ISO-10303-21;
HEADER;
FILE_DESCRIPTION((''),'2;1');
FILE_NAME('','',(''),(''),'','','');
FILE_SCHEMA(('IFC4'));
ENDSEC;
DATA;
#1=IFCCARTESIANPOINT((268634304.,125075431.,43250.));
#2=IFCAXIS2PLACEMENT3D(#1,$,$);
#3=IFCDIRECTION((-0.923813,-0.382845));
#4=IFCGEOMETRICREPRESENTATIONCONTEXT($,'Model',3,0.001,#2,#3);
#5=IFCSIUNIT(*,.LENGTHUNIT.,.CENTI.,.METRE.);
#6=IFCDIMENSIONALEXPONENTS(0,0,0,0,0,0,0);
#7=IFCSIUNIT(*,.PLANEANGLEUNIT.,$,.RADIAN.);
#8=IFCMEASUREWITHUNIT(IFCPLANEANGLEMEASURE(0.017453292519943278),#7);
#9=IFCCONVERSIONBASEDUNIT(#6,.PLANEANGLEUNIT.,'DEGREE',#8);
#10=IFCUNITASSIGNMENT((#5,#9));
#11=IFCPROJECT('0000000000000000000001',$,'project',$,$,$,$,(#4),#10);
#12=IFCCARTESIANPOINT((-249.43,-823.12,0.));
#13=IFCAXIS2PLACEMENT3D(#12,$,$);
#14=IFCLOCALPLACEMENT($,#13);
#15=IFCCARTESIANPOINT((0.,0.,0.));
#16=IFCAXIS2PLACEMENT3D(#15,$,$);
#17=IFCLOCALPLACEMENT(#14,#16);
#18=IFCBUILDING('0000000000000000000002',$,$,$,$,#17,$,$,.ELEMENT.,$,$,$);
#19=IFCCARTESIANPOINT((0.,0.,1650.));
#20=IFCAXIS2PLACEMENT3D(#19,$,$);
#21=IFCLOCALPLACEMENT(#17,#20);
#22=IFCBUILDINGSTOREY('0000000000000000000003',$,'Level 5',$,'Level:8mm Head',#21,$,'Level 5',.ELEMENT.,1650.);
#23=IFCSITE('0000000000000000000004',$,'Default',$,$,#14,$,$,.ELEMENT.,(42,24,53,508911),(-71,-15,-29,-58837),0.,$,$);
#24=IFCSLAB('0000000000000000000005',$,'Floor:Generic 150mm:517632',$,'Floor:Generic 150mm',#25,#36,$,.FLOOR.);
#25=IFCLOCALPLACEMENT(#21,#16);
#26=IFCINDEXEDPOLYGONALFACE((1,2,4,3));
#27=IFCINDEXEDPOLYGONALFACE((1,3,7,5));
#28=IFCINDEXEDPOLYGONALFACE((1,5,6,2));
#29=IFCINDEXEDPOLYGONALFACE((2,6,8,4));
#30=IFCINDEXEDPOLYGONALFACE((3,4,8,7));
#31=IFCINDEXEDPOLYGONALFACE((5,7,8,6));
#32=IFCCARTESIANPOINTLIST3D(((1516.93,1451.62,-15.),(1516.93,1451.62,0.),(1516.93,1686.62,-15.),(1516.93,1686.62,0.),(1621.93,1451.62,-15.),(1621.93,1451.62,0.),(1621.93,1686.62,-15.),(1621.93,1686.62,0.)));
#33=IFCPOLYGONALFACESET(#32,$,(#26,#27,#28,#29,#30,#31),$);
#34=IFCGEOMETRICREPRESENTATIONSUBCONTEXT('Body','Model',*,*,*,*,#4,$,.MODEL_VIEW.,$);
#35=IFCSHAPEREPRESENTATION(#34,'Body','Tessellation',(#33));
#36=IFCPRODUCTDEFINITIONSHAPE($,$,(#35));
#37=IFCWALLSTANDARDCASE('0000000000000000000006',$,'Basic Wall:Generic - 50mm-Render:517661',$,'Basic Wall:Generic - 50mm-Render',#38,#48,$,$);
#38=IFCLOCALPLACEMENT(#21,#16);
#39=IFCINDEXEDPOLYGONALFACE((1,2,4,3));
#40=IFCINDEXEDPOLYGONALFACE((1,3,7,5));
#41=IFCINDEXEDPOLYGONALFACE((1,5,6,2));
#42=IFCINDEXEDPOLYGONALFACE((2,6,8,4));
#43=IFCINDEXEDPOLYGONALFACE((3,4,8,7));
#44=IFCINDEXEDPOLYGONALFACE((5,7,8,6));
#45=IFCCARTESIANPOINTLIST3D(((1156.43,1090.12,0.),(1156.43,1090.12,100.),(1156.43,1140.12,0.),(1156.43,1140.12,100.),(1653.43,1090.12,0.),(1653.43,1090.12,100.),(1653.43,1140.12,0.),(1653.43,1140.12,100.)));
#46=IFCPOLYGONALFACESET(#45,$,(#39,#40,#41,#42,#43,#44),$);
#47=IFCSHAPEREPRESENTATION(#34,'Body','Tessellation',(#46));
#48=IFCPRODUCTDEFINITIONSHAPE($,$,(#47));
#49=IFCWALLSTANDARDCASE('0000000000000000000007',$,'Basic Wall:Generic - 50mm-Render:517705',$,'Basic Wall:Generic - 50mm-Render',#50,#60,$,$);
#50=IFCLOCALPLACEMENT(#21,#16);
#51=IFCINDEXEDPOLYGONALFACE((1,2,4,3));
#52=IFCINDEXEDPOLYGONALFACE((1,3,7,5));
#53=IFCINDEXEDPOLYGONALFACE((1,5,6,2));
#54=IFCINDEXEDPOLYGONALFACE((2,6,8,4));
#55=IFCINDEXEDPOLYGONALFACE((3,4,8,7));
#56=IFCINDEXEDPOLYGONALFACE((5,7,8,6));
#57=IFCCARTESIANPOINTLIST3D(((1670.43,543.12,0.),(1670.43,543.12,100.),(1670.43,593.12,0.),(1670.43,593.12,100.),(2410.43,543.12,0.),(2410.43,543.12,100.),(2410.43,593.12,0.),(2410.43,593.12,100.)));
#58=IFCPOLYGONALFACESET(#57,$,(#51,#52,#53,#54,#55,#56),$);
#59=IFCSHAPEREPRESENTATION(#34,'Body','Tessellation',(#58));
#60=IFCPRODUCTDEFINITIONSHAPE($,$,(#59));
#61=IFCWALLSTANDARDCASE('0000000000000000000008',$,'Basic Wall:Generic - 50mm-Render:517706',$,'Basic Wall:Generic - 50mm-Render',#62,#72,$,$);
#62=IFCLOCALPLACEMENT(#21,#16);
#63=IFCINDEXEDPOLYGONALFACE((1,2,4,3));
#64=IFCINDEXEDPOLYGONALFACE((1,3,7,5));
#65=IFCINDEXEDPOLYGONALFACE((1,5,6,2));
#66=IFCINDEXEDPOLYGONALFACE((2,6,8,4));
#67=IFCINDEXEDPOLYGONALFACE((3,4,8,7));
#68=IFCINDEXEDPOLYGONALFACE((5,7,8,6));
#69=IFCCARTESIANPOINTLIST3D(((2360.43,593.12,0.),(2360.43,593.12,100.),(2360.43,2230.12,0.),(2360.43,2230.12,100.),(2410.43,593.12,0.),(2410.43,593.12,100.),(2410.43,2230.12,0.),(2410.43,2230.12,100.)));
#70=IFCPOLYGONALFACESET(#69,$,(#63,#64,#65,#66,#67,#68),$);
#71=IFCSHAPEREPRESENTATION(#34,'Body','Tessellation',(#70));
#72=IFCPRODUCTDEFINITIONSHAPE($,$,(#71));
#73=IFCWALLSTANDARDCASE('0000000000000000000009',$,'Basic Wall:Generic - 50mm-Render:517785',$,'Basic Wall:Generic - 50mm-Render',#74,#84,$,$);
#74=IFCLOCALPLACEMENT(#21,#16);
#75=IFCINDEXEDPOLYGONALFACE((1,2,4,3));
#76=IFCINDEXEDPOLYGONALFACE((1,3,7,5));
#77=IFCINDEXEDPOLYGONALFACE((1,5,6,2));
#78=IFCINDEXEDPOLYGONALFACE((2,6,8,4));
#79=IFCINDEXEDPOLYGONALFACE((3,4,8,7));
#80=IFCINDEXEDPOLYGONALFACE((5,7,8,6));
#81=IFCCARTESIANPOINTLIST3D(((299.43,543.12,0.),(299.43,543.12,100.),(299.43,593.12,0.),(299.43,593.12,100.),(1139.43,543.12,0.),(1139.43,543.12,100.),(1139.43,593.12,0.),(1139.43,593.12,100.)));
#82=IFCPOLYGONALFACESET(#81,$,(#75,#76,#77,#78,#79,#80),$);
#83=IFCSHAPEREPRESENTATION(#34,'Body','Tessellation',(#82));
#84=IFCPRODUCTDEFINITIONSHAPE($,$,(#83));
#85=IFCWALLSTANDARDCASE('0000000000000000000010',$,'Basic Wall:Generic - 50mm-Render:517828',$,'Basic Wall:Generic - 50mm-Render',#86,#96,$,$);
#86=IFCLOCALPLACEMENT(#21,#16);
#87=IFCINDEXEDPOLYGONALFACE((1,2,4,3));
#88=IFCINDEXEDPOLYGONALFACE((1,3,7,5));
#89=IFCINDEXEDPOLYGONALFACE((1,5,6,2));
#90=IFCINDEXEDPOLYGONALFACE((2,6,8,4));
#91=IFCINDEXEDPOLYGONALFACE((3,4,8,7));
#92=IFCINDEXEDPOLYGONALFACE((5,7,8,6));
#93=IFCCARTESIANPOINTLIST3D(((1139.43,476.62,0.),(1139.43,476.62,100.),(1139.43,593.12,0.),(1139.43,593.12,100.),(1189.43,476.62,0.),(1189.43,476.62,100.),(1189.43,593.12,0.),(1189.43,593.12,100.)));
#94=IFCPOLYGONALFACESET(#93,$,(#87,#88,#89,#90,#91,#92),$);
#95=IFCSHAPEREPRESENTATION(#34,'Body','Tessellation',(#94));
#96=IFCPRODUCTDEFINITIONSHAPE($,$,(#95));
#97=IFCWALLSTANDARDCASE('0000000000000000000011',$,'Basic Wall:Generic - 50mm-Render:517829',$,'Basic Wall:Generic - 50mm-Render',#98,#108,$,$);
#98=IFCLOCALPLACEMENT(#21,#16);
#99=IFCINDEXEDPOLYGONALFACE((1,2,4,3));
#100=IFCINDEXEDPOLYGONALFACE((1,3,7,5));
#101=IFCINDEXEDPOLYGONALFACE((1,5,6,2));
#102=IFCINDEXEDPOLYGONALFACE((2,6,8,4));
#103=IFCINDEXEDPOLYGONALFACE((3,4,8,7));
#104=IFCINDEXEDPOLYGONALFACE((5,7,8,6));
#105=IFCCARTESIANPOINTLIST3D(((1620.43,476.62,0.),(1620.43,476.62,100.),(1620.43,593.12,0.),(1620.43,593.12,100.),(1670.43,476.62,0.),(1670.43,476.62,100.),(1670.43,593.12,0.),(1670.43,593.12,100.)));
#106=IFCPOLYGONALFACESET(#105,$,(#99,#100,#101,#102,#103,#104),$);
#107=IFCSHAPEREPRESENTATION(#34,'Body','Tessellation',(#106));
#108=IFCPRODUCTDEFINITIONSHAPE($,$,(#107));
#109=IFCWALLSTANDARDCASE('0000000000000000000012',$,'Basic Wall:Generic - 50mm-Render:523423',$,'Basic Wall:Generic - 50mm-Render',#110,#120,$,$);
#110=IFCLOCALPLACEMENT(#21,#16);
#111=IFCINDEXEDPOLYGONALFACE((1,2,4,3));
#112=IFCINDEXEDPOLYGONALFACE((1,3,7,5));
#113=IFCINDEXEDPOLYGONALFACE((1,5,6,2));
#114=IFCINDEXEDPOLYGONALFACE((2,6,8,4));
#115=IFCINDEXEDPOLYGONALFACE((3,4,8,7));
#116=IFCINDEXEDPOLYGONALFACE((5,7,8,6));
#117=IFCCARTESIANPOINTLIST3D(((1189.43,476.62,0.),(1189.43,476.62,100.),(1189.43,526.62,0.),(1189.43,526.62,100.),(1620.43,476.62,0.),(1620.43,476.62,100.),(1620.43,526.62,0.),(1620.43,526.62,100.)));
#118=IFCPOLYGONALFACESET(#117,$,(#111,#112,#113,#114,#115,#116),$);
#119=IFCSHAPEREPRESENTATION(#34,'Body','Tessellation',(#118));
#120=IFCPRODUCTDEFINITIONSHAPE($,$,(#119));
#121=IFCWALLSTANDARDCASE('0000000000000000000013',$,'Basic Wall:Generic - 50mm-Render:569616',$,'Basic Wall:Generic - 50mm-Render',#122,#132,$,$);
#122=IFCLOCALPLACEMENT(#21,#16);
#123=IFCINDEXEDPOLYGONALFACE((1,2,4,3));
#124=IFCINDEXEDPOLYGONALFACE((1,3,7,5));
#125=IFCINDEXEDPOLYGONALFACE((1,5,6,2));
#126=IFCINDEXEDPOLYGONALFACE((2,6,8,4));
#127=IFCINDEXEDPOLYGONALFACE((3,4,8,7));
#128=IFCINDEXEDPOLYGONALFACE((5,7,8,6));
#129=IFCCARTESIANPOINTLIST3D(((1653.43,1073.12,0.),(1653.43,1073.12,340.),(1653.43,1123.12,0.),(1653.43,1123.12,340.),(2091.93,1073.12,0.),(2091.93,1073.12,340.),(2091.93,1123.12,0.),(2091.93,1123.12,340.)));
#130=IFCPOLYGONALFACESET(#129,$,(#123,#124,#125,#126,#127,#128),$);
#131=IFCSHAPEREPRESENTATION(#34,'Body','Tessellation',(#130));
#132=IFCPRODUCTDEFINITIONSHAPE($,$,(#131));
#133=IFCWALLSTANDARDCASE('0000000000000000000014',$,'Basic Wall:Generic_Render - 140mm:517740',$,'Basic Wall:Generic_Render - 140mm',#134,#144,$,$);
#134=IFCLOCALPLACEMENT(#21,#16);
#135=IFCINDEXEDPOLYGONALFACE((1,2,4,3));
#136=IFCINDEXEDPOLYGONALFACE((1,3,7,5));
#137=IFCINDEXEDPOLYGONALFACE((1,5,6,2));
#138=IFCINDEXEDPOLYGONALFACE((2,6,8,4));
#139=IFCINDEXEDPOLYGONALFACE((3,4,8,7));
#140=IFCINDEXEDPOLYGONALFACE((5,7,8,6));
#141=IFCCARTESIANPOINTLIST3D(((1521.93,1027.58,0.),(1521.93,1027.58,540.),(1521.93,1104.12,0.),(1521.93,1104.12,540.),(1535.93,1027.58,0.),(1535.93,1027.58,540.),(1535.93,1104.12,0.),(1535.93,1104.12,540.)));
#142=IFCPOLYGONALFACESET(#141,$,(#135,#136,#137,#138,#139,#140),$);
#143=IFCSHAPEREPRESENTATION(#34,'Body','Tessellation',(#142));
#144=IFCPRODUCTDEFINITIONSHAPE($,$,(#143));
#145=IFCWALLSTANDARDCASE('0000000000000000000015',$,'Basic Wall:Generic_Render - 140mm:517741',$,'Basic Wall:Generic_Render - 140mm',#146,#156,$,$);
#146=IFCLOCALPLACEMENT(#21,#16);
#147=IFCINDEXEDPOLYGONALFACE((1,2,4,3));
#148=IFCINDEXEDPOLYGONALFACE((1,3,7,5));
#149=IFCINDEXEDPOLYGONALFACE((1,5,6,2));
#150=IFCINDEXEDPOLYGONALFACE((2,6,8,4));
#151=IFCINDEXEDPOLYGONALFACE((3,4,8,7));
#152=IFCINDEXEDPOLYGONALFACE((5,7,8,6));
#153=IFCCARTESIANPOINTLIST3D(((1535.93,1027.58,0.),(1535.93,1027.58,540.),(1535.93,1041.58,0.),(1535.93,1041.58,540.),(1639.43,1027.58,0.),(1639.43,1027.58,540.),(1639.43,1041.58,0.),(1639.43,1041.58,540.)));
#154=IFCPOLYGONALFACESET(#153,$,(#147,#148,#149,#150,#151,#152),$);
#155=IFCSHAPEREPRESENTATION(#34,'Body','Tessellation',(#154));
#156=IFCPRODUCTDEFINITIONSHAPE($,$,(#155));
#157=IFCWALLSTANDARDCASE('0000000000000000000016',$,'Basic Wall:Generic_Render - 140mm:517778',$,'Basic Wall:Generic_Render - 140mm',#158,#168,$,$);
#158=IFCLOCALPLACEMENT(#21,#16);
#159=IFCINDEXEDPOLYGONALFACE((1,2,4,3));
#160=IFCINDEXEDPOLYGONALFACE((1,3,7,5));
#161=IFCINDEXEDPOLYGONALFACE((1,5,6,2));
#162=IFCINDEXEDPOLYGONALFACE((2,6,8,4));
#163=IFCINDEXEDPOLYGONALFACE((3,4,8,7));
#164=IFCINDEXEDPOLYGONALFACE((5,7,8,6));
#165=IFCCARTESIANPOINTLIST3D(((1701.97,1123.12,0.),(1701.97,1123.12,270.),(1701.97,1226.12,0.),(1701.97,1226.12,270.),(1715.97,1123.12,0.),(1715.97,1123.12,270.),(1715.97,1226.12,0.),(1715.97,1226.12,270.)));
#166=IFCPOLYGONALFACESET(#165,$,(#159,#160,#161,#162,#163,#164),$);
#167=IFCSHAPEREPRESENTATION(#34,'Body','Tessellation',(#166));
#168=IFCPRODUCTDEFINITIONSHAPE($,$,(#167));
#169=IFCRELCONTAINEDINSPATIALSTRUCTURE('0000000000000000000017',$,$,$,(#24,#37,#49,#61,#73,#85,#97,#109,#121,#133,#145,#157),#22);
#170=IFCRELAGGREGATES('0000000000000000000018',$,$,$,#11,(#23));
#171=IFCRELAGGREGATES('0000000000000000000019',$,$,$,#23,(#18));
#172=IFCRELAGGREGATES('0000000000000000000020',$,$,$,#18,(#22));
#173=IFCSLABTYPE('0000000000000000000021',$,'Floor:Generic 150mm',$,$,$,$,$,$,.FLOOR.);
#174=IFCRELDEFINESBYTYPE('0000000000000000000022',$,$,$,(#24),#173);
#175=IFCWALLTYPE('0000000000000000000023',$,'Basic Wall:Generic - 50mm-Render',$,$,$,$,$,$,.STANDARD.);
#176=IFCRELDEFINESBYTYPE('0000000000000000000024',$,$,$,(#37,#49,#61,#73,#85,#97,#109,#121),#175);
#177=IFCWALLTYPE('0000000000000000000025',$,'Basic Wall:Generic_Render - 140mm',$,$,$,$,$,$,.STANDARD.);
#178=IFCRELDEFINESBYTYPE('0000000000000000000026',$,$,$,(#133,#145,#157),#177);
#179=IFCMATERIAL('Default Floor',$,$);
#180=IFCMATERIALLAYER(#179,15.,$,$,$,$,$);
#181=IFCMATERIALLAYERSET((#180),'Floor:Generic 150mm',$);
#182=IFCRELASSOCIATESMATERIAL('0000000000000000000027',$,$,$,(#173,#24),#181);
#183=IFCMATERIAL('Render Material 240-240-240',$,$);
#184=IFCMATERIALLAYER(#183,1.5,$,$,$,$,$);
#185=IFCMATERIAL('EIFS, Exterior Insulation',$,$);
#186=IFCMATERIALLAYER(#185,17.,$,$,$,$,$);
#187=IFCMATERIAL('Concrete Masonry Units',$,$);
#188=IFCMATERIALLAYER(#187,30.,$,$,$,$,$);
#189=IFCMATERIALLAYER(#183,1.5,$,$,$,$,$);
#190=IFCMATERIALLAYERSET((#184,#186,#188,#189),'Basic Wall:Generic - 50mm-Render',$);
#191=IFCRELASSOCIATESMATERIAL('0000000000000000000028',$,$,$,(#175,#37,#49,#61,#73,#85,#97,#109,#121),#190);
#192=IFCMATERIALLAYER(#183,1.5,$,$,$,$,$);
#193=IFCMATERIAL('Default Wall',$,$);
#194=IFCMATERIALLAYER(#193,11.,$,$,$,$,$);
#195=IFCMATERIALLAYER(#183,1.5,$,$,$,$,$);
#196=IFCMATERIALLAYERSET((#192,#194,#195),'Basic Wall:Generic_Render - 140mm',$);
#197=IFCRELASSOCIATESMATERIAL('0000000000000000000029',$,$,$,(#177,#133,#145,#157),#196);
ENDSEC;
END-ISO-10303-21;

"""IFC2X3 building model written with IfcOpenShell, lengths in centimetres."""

from ifc_helpers import new_model, entity, si_unit, converted_unit, direction, frame, frame_2d, origin, origin_2d_with_axis, place, context, subcontext, project, spatial, rectangle, extrude, material, layer, layer_set, layer_usage, type_object, element, save


model = new_model("IFC2X3")

# Units and contexts
model_context = context("Model", 3, precision=0.001, world=frame((268634304.0, 125075431.0, 43250.0)), true_north=direction((-0.923813, -0.382845)))
body_context = subcontext(model_context, "Body", "Model", "MODEL_VIEW")
ifc_project = project(units=[si_unit("LENGTHUNIT", "METRE", prefix="CENTI"), converted_unit("PLANEANGLEUNIT", "DEGREE", entity("IfcPlaneAngleMeasure", 0.017453292519943278), si_unit("PLANEANGLEUNIT", "RADIAN"), dimensions=[0, 0, 0, 0, 0, 0, 0])], contexts=[model_context])

# Site, building, storey
site_placement = place(None, frame((-249.43, -823.12, 0.0)))
site = spatial("IfcSite", under=ifc_project, at=site_placement, Name="Default", CompositionType="ELEMENT", RefLatitude=(42, 24, 53, 508911), RefLongitude=(-71, -15, -29, -58837), RefElevation=0.0)
building_placement = place(site_placement, origin())
building = spatial("IfcBuilding", under=site, at=building_placement, CompositionType="ELEMENT")
storey_placement = place(building_placement, frame((0.0, 0.0, 1650.0)))
storey = spatial("IfcBuildingStorey", under=building, at=storey_placement, Name="Level 5", ObjectType="Level:8mm Head", LongName="Level 5", CompositionType="ELEMENT", Elevation=1650.0)

# Slab
ifc_material_1 = material(Name="Default Floor")
ifc_layer_1 = layer(ifc_material_1, 15.0)
ifc_layer_set_1 = layer_set([ifc_layer_1], Name="Floor:Generic 150mm")
ifc_layer_usage_1 = layer_usage(ifc_layer_set_1, "AXIS3", "POSITIVE", 0.0)
slab_type_1 = type_object("IfcSlabType", Name="Floor:Generic 150mm", PredefinedType="FLOOR", material=ifc_layer_set_1)
slab_1_placement = place(storey_placement, origin())
element("IfcSlab", 1, at=slab_1_placement, inside=storey, type_object=slab_type_1, material=ifc_layer_usage_1, Name="Floor:Generic 150mm:517632", ObjectType="Floor:Generic 150mm", PredefinedType="FLOOR", context=body_context, shape_type="SweptSolid", body=[
    extrude(rectangle(XDim=235.0, YDim=105.0, at=origin_2d_with_axis()), frame((1569.43, 1569.12, 0.0), z_axis=(0.0, 0.0, -1.0), x_axis=(0.0, 1.0, 0.0)), (0.0, 0.0, 1.0), 15.0),
])

# Walls
ifc_material_2 = material(Name="Render Material 240-240-240")
ifc_layer_2 = layer(ifc_material_2, 1.5)
ifc_material_3 = material(Name="EIFS, Exterior Insulation")
ifc_layer_3 = layer(ifc_material_3, 17.0)
ifc_material_4 = material(Name="Concrete Masonry Units")
ifc_layer_4 = layer(ifc_material_4, 30.0)
ifc_layer_5 = layer(ifc_material_2, 1.5)
ifc_layer_set_2 = layer_set([ifc_layer_2, ifc_layer_3, ifc_layer_4, ifc_layer_5], Name="Basic Wall:Generic - 50mm-Render")
ifc_layer_usage_2 = layer_usage(ifc_layer_set_2, "AXIS2", "NEGATIVE", 25.0)
wall_type_1 = type_object("IfcWallType", Name="Basic Wall:Generic - 50mm-Render", PredefinedType="STANDARD", material=ifc_layer_set_2)
wall_1_placement = place(storey_placement, frame((1156.43, 1115.12, 0.0)))
element("IfcWallStandardCase", 2, at=wall_1_placement, inside=storey, type_object=wall_type_1, material=ifc_layer_usage_2, Name="Basic Wall:Generic - 50mm-Render:517661", ObjectType="Basic Wall:Generic - 50mm-Render", context=body_context, shape_type="SweptSolid", body=[
    extrude(rectangle(XDim=497.0, YDim=50.0, at=frame_2d((248.5, 0.0), x_axis=(-1.0, 0.0))), origin(), (0.0, 0.0, 1.0), 100.0),
])
ifc_layer_usage_3 = layer_usage(ifc_layer_set_2, "AXIS2", "POSITIVE", -25.0)
wall_2_placement = place(storey_placement, frame((1670.43, 568.12, 0.0)))
element("IfcWallStandardCase", 3, at=wall_2_placement, inside=storey, type_object=wall_type_1, material=ifc_layer_usage_3, Name="Basic Wall:Generic - 50mm-Render:517705", ObjectType="Basic Wall:Generic - 50mm-Render", context=body_context, shape_type="SweptSolid", body=[
    extrude(rectangle(XDim=740.0, YDim=50.0, at=frame_2d((370.0, 0.0), x_axis=(-1.0, 0.0))), origin(), (0.0, 0.0, 1.0), 100.0),
])
ifc_layer_usage_4 = layer_usage(ifc_layer_set_2, "AXIS2", "POSITIVE", -25.0)
wall_3_placement = place(storey_placement, frame((2385.43, 593.12, 0.0), z_axis=(0.0, 0.0, 1.0), x_axis=(0.0, 1.0, 0.0)))
element("IfcWallStandardCase", 4, at=wall_3_placement, inside=storey, type_object=wall_type_1, material=ifc_layer_usage_4, Name="Basic Wall:Generic - 50mm-Render:517706", ObjectType="Basic Wall:Generic - 50mm-Render", context=body_context, shape_type="SweptSolid", body=[
    extrude(rectangle(XDim=1637.0, YDim=50.0, at=frame_2d((818.5, 0.0), x_axis=(-1.0, 0.0))), origin(), (0.0, 0.0, 1.0), 100.0),
])
ifc_layer_usage_5 = layer_usage(ifc_layer_set_2, "AXIS2", "NEGATIVE", 25.0)
wall_4_placement = place(storey_placement, frame((1139.43, 568.12, 0.0), z_axis=(0.0, 0.0, 1.0), x_axis=(-1.0, 0.0, 0.0)))
element("IfcWallStandardCase", 5, at=wall_4_placement, inside=storey, type_object=wall_type_1, material=ifc_layer_usage_5, Name="Basic Wall:Generic - 50mm-Render:517785", ObjectType="Basic Wall:Generic - 50mm-Render", context=body_context, shape_type="SweptSolid", body=[
    extrude(rectangle(XDim=840.0, YDim=50.0, at=frame_2d((420.0, 0.0), x_axis=(-1.0, 0.0))), origin(), (0.0, 0.0, 1.0), 100.0),
])
ifc_layer_usage_6 = layer_usage(ifc_layer_set_2, "AXIS2", "POSITIVE", -25.0)
wall_5_placement = place(storey_placement, frame((1164.43, 593.12, 0.0), z_axis=(0.0, 0.0, 1.0), x_axis=(0.0, -1.0, 0.0)))
element("IfcWallStandardCase", 6, at=wall_5_placement, inside=storey, type_object=wall_type_1, material=ifc_layer_usage_6, Name="Basic Wall:Generic - 50mm-Render:517828", ObjectType="Basic Wall:Generic - 50mm-Render", context=body_context, shape_type="SweptSolid", body=[
    extrude(rectangle(XDim=116.5, YDim=50.0, at=frame_2d((58.25, 0.0), x_axis=(-1.0, 0.0))), origin(), (0.0, 0.0, 1.0), 100.0),
])
ifc_layer_usage_7 = layer_usage(ifc_layer_set_2, "AXIS2", "NEGATIVE", 25.0)
wall_6_placement = place(storey_placement, frame((1645.43, 593.12, 0.0), z_axis=(0.0, 0.0, 1.0), x_axis=(0.0, -1.0, 0.0)))
element("IfcWallStandardCase", 7, at=wall_6_placement, inside=storey, type_object=wall_type_1, material=ifc_layer_usage_7, Name="Basic Wall:Generic - 50mm-Render:517829", ObjectType="Basic Wall:Generic - 50mm-Render", context=body_context, shape_type="SweptSolid", body=[
    extrude(rectangle(XDim=116.5, YDim=50.0, at=frame_2d((58.25, 0.0), x_axis=(-1.0, 0.0))), origin(), (0.0, 0.0, 1.0), 100.0),
])
ifc_layer_usage_8 = layer_usage(ifc_layer_set_2, "AXIS2", "NEGATIVE", 25.0)
wall_7_placement = place(storey_placement, frame((1620.43, 501.62, 0.0), z_axis=(0.0, 0.0, 1.0), x_axis=(-1.0, 0.0, 0.0)))
element("IfcWallStandardCase", 8, at=wall_7_placement, inside=storey, type_object=wall_type_1, material=ifc_layer_usage_8, Name="Basic Wall:Generic - 50mm-Render:523423", ObjectType="Basic Wall:Generic - 50mm-Render", context=body_context, shape_type="SweptSolid", body=[
    extrude(rectangle(XDim=431.0, YDim=50.0, at=frame_2d((215.5, 0.0), x_axis=(-1.0, 0.0))), origin(), (0.0, 0.0, 1.0), 100.0),
])
ifc_layer_usage_9 = layer_usage(ifc_layer_set_2, "AXIS2", "NEGATIVE", 25.0)
wall_8_placement = place(storey_placement, frame((2091.93, 1098.12, 0.0), z_axis=(0.0, 0.0, 1.0), x_axis=(-1.0, 0.0, 0.0)))
element("IfcWallStandardCase", 9, at=wall_8_placement, inside=storey, type_object=wall_type_1, material=ifc_layer_usage_9, Name="Basic Wall:Generic - 50mm-Render:569616", ObjectType="Basic Wall:Generic - 50mm-Render", context=body_context, shape_type="SweptSolid", body=[
    extrude(rectangle(XDim=438.5, YDim=50.0, at=frame_2d((219.25, 0.0), x_axis=(-1.0, 0.0))), origin(), (0.0, 0.0, 1.0), 340.0),
])
ifc_layer_6 = layer(ifc_material_2, 1.5)
ifc_material_5 = material(Name="Default Wall")
ifc_layer_7 = layer(ifc_material_5, 11.0)
ifc_layer_8 = layer(ifc_material_2, 1.5)
ifc_layer_set_3 = layer_set([ifc_layer_6, ifc_layer_7, ifc_layer_8], Name="Basic Wall:Generic_Render - 140mm")
ifc_layer_usage_10 = layer_usage(ifc_layer_set_3, "AXIS2", "POSITIVE", -7.0)
wall_type_2 = type_object("IfcWallType", Name="Basic Wall:Generic_Render - 140mm", PredefinedType="STANDARD", material=ifc_layer_set_3)
wall_9_placement = place(storey_placement, frame((1528.93, 1104.12, 0.0), z_axis=(0.0, 0.0, 1.0), x_axis=(0.0, -1.0, 0.0)))
element("IfcWallStandardCase", 10, at=wall_9_placement, inside=storey, type_object=wall_type_2, material=ifc_layer_usage_10, Name="Basic Wall:Generic_Render - 140mm:517740", ObjectType="Basic Wall:Generic_Render - 140mm", context=body_context, shape_type="SweptSolid", body=[
    extrude(rectangle(XDim=76.54, YDim=14.0, at=frame_2d((38.27, 0.0), x_axis=(-1.0, 0.0))), origin(), (0.0, 0.0, 1.0), 540.0),
])
ifc_layer_usage_11 = layer_usage(ifc_layer_set_3, "AXIS2", "POSITIVE", -7.0)
wall_10_placement = place(storey_placement, frame((1535.93, 1034.58, 0.0)))
element("IfcWallStandardCase", 11, at=wall_10_placement, inside=storey, type_object=wall_type_2, material=ifc_layer_usage_11, Name="Basic Wall:Generic_Render - 140mm:517741", ObjectType="Basic Wall:Generic_Render - 140mm", context=body_context, shape_type="SweptSolid", body=[
    extrude(rectangle(XDim=103.5, YDim=14.0, at=frame_2d((51.75, 0.0), x_axis=(-1.0, 0.0))), origin(), (0.0, 0.0, 1.0), 540.0),
])
ifc_layer_usage_12 = layer_usage(ifc_layer_set_3, "AXIS2", "NEGATIVE", 7.0)
wall_11_placement = place(storey_placement, frame((1708.97, 1226.12, 0.0), z_axis=(0.0, 0.0, 1.0), x_axis=(0.0, -1.0, 0.0)))
element("IfcWallStandardCase", 12, at=wall_11_placement, inside=storey, type_object=wall_type_2, material=ifc_layer_usage_12, Name="Basic Wall:Generic_Render - 140mm:517778", ObjectType="Basic Wall:Generic_Render - 140mm", context=body_context, shape_type="SweptSolid", body=[
    extrude(rectangle(XDim=103.0, YDim=14.0, at=frame_2d((51.5, 0.0), x_axis=(-1.0, 0.0))), origin(), (0.0, 0.0, 1.0), 270.0),
])

save(model, "model.ifc")
